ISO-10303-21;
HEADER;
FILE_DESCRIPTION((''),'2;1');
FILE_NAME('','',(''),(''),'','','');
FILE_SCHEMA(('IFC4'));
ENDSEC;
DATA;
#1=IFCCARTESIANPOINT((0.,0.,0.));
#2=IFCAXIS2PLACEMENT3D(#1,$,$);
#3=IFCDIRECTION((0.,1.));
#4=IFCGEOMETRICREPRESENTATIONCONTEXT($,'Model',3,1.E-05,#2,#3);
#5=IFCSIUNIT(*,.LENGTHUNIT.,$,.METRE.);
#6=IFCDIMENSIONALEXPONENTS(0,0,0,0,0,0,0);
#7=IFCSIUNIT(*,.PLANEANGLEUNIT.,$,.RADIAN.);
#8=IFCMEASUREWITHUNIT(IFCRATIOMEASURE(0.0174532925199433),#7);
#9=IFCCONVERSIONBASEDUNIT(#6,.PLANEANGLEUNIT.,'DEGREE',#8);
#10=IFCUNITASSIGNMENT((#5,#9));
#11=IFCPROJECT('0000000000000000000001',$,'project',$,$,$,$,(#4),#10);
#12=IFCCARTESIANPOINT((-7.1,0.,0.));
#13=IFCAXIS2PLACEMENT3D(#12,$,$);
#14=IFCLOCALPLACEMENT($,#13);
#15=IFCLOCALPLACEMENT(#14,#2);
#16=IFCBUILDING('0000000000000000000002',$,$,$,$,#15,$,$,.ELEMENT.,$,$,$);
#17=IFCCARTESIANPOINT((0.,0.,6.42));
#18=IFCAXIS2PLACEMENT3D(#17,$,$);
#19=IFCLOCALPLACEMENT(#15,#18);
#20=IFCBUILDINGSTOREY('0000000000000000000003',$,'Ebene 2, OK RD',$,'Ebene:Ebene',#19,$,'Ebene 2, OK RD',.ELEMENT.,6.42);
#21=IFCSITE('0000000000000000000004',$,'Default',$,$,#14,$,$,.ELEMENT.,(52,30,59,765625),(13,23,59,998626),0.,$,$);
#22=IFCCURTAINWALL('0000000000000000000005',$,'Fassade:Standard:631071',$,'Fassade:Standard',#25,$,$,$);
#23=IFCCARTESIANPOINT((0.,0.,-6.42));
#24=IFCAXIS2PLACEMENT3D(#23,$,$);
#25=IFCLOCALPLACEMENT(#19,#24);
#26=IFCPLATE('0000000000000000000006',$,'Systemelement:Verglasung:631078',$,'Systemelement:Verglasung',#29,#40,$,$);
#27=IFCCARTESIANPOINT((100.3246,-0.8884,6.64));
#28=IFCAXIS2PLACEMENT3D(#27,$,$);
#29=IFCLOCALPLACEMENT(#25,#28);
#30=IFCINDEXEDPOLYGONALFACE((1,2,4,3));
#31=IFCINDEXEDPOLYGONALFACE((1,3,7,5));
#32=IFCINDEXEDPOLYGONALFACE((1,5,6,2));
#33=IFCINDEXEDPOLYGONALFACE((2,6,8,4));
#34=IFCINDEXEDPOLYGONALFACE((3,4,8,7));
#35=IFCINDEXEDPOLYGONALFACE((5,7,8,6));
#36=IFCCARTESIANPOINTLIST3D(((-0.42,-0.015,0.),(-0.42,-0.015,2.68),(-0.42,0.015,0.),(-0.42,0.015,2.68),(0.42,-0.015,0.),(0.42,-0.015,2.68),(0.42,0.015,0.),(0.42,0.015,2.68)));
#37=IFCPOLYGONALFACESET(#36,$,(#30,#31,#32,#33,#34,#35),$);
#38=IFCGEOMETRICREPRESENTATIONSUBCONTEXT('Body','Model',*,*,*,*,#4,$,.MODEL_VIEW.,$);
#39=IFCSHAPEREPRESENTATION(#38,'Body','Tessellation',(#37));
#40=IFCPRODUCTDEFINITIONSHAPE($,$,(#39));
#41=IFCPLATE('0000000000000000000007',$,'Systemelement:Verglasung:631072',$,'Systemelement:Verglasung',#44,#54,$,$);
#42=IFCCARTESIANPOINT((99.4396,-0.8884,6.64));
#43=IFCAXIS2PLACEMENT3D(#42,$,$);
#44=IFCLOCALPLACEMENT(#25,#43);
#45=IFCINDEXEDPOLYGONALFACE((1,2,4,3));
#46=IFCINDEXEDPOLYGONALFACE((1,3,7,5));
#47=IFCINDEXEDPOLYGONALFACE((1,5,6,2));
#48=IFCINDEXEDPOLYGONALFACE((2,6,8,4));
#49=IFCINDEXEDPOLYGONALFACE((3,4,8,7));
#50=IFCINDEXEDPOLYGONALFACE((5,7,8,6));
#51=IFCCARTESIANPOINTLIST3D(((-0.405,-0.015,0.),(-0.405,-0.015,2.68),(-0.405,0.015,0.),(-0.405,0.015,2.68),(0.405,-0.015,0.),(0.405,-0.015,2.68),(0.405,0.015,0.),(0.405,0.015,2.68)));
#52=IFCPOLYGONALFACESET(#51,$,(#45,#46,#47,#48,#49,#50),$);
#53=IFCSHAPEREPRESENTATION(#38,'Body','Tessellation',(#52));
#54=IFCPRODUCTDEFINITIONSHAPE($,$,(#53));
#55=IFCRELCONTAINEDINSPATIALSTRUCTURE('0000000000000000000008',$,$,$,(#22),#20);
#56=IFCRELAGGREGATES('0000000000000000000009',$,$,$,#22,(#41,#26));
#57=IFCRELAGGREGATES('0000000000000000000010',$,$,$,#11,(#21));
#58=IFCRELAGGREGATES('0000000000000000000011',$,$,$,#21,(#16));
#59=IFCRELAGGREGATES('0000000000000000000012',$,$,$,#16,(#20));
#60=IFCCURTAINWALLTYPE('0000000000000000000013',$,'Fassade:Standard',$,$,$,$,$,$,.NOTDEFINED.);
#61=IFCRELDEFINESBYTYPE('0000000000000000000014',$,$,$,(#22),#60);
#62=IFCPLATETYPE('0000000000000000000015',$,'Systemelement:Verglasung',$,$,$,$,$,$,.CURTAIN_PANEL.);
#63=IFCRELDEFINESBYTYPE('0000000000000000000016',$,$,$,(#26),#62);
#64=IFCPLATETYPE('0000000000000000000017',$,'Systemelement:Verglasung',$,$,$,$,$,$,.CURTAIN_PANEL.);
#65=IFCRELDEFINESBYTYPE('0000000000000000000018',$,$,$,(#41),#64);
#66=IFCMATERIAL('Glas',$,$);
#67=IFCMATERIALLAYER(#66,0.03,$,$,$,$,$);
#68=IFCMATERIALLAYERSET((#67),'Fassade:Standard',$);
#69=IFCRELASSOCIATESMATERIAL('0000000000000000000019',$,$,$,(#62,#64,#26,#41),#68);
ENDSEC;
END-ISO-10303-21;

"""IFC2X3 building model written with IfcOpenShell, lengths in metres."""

from ifc_helpers import new_model, entity, si_unit, converted_unit, direction, frame, origin, origin_2d_with_axis, place, context, subcontext, project, spatial, rectangle, extrude, source, transform, mapped, material, layer, layer_set, layer_usage, type_object, type_shapes, element, aggregate, save


model = new_model("IFC2X3")

# Units and contexts
model_context = context("Model", 3, precision=1e-05, world=origin(), true_north=direction((0.0, 1.0)))
body_context = subcontext(model_context, "Body", "Model", "MODEL_VIEW")
ifc_project = project(units=[si_unit("LENGTHUNIT", "METRE"), converted_unit("PLANEANGLEUNIT", "DEGREE", entity("IfcRatioMeasure", 0.0174532925199433), si_unit("PLANEANGLEUNIT", "RADIAN"), dimensions=[0, 0, 0, 0, 0, 0, 0])], contexts=[model_context])

# Site, building, storey
site_placement = place(None, frame((-7.1, 0.0, 0.0)))
site = spatial("IfcSite", under=ifc_project, at=site_placement, Name="Default", CompositionType="ELEMENT", RefLatitude=(52, 30, 59, 765625), RefLongitude=(13, 23, 59, 998626), RefElevation=0.0)
building_placement = place(site_placement, origin())
building = spatial("IfcBuilding", under=site, at=building_placement, CompositionType="ELEMENT")
storey_placement = place(building_placement, frame((0.0, 0.0, 6.42)))
storey = spatial("IfcBuildingStorey", under=building, at=storey_placement, Name="Ebene 2, OK RD", ObjectType="Ebene:Ebene", LongName="Ebene 2, OK RD", CompositionType="ELEMENT", Elevation=6.42)

# Curtain wall
curtain_wall_type = type_object("IfcCurtainWallType", Name="Fassade:Standard", PredefinedType="NOTDEFINED")
curtain_wall_placement = place(storey_placement, frame((0.0, 0.0, -6.42)))
curtain_wall = element("IfcCurtainWall", 1, at=curtain_wall_placement, inside=storey, type_object=curtain_wall_type, Name="Fassade:Standard:631071", ObjectType="Fassade:Standard")

# Plates
ifc_material_1 = material(Name="Glas")
ifc_layer_1 = layer(ifc_material_1, 0.03)
ifc_layer_set_1 = layer_set([ifc_layer_1], Name="Fassade:Standard")
ifc_layer_usage_1 = layer_usage(ifc_layer_set_1, "AXIS3", "POSITIVE", 0.0)
plate_type_1 = type_object("IfcPlateType", Name="Systemelement:Verglasung", PredefinedType="CURTAIN_PANEL", material=ifc_layer_set_1)
shared_shape_1 = source(origin(), body_context, "Body", "SweptSolid", [
    extrude(rectangle(XDim=0.03, YDim=0.84, at=origin_2d_with_axis()), frame((0.0, 0.0, 0.0), z_axis=(0.0, 0.0, 1.0), x_axis=(0.0, 1.0, 0.0)), (0.0, 0.0, 1.0), 2.68),
])
type_shapes(plate_type_1, [shared_shape_1])
plate_1_placement = place(curtain_wall_placement, frame((100.3246, -0.8884, 6.64)))
plate_1 = element("IfcPlate", 2, at=plate_1_placement, type_object=plate_type_1, material=ifc_layer_usage_1, Name="Systemelement:Verglasung:631078", ObjectType="Systemelement:Verglasung", context=body_context, shape_type="MappedRepresentation", body=[
    mapped(shared_shape_1, transform((0.0, 0.0, 0.0), scale=1.0)),
])
ifc_layer_usage_2 = layer_usage(ifc_layer_set_1, "AXIS3", "POSITIVE", 0.0)
plate_type_2 = type_object("IfcPlateType", Name="Systemelement:Verglasung", PredefinedType="CURTAIN_PANEL", material=ifc_layer_set_1)
shared_shape_2 = source(origin(), body_context, "Body", "SweptSolid", [
    extrude(rectangle(XDim=0.03, YDim=0.81, at=origin_2d_with_axis()), frame((0.0, 0.0, 0.0), z_axis=(0.0, 0.0, 1.0), x_axis=(0.0, 1.0, 0.0)), (0.0, 0.0, 1.0), 2.68),
])
type_shapes(plate_type_2, [shared_shape_2])
plate_2_placement = place(curtain_wall_placement, frame((99.4396, -0.8884, 6.64)))
plate_2 = element("IfcPlate", 3, at=plate_2_placement, type_object=plate_type_2, material=ifc_layer_usage_2, Name="Systemelement:Verglasung:631072", ObjectType="Systemelement:Verglasung", context=body_context, shape_type="MappedRepresentation", body=[
    mapped(shared_shape_2, transform((0.0, 0.0, 0.0), scale=1.0)),
])
aggregate(curtain_wall, [plate_2, plate_1])

save(model, "model.ifc")
